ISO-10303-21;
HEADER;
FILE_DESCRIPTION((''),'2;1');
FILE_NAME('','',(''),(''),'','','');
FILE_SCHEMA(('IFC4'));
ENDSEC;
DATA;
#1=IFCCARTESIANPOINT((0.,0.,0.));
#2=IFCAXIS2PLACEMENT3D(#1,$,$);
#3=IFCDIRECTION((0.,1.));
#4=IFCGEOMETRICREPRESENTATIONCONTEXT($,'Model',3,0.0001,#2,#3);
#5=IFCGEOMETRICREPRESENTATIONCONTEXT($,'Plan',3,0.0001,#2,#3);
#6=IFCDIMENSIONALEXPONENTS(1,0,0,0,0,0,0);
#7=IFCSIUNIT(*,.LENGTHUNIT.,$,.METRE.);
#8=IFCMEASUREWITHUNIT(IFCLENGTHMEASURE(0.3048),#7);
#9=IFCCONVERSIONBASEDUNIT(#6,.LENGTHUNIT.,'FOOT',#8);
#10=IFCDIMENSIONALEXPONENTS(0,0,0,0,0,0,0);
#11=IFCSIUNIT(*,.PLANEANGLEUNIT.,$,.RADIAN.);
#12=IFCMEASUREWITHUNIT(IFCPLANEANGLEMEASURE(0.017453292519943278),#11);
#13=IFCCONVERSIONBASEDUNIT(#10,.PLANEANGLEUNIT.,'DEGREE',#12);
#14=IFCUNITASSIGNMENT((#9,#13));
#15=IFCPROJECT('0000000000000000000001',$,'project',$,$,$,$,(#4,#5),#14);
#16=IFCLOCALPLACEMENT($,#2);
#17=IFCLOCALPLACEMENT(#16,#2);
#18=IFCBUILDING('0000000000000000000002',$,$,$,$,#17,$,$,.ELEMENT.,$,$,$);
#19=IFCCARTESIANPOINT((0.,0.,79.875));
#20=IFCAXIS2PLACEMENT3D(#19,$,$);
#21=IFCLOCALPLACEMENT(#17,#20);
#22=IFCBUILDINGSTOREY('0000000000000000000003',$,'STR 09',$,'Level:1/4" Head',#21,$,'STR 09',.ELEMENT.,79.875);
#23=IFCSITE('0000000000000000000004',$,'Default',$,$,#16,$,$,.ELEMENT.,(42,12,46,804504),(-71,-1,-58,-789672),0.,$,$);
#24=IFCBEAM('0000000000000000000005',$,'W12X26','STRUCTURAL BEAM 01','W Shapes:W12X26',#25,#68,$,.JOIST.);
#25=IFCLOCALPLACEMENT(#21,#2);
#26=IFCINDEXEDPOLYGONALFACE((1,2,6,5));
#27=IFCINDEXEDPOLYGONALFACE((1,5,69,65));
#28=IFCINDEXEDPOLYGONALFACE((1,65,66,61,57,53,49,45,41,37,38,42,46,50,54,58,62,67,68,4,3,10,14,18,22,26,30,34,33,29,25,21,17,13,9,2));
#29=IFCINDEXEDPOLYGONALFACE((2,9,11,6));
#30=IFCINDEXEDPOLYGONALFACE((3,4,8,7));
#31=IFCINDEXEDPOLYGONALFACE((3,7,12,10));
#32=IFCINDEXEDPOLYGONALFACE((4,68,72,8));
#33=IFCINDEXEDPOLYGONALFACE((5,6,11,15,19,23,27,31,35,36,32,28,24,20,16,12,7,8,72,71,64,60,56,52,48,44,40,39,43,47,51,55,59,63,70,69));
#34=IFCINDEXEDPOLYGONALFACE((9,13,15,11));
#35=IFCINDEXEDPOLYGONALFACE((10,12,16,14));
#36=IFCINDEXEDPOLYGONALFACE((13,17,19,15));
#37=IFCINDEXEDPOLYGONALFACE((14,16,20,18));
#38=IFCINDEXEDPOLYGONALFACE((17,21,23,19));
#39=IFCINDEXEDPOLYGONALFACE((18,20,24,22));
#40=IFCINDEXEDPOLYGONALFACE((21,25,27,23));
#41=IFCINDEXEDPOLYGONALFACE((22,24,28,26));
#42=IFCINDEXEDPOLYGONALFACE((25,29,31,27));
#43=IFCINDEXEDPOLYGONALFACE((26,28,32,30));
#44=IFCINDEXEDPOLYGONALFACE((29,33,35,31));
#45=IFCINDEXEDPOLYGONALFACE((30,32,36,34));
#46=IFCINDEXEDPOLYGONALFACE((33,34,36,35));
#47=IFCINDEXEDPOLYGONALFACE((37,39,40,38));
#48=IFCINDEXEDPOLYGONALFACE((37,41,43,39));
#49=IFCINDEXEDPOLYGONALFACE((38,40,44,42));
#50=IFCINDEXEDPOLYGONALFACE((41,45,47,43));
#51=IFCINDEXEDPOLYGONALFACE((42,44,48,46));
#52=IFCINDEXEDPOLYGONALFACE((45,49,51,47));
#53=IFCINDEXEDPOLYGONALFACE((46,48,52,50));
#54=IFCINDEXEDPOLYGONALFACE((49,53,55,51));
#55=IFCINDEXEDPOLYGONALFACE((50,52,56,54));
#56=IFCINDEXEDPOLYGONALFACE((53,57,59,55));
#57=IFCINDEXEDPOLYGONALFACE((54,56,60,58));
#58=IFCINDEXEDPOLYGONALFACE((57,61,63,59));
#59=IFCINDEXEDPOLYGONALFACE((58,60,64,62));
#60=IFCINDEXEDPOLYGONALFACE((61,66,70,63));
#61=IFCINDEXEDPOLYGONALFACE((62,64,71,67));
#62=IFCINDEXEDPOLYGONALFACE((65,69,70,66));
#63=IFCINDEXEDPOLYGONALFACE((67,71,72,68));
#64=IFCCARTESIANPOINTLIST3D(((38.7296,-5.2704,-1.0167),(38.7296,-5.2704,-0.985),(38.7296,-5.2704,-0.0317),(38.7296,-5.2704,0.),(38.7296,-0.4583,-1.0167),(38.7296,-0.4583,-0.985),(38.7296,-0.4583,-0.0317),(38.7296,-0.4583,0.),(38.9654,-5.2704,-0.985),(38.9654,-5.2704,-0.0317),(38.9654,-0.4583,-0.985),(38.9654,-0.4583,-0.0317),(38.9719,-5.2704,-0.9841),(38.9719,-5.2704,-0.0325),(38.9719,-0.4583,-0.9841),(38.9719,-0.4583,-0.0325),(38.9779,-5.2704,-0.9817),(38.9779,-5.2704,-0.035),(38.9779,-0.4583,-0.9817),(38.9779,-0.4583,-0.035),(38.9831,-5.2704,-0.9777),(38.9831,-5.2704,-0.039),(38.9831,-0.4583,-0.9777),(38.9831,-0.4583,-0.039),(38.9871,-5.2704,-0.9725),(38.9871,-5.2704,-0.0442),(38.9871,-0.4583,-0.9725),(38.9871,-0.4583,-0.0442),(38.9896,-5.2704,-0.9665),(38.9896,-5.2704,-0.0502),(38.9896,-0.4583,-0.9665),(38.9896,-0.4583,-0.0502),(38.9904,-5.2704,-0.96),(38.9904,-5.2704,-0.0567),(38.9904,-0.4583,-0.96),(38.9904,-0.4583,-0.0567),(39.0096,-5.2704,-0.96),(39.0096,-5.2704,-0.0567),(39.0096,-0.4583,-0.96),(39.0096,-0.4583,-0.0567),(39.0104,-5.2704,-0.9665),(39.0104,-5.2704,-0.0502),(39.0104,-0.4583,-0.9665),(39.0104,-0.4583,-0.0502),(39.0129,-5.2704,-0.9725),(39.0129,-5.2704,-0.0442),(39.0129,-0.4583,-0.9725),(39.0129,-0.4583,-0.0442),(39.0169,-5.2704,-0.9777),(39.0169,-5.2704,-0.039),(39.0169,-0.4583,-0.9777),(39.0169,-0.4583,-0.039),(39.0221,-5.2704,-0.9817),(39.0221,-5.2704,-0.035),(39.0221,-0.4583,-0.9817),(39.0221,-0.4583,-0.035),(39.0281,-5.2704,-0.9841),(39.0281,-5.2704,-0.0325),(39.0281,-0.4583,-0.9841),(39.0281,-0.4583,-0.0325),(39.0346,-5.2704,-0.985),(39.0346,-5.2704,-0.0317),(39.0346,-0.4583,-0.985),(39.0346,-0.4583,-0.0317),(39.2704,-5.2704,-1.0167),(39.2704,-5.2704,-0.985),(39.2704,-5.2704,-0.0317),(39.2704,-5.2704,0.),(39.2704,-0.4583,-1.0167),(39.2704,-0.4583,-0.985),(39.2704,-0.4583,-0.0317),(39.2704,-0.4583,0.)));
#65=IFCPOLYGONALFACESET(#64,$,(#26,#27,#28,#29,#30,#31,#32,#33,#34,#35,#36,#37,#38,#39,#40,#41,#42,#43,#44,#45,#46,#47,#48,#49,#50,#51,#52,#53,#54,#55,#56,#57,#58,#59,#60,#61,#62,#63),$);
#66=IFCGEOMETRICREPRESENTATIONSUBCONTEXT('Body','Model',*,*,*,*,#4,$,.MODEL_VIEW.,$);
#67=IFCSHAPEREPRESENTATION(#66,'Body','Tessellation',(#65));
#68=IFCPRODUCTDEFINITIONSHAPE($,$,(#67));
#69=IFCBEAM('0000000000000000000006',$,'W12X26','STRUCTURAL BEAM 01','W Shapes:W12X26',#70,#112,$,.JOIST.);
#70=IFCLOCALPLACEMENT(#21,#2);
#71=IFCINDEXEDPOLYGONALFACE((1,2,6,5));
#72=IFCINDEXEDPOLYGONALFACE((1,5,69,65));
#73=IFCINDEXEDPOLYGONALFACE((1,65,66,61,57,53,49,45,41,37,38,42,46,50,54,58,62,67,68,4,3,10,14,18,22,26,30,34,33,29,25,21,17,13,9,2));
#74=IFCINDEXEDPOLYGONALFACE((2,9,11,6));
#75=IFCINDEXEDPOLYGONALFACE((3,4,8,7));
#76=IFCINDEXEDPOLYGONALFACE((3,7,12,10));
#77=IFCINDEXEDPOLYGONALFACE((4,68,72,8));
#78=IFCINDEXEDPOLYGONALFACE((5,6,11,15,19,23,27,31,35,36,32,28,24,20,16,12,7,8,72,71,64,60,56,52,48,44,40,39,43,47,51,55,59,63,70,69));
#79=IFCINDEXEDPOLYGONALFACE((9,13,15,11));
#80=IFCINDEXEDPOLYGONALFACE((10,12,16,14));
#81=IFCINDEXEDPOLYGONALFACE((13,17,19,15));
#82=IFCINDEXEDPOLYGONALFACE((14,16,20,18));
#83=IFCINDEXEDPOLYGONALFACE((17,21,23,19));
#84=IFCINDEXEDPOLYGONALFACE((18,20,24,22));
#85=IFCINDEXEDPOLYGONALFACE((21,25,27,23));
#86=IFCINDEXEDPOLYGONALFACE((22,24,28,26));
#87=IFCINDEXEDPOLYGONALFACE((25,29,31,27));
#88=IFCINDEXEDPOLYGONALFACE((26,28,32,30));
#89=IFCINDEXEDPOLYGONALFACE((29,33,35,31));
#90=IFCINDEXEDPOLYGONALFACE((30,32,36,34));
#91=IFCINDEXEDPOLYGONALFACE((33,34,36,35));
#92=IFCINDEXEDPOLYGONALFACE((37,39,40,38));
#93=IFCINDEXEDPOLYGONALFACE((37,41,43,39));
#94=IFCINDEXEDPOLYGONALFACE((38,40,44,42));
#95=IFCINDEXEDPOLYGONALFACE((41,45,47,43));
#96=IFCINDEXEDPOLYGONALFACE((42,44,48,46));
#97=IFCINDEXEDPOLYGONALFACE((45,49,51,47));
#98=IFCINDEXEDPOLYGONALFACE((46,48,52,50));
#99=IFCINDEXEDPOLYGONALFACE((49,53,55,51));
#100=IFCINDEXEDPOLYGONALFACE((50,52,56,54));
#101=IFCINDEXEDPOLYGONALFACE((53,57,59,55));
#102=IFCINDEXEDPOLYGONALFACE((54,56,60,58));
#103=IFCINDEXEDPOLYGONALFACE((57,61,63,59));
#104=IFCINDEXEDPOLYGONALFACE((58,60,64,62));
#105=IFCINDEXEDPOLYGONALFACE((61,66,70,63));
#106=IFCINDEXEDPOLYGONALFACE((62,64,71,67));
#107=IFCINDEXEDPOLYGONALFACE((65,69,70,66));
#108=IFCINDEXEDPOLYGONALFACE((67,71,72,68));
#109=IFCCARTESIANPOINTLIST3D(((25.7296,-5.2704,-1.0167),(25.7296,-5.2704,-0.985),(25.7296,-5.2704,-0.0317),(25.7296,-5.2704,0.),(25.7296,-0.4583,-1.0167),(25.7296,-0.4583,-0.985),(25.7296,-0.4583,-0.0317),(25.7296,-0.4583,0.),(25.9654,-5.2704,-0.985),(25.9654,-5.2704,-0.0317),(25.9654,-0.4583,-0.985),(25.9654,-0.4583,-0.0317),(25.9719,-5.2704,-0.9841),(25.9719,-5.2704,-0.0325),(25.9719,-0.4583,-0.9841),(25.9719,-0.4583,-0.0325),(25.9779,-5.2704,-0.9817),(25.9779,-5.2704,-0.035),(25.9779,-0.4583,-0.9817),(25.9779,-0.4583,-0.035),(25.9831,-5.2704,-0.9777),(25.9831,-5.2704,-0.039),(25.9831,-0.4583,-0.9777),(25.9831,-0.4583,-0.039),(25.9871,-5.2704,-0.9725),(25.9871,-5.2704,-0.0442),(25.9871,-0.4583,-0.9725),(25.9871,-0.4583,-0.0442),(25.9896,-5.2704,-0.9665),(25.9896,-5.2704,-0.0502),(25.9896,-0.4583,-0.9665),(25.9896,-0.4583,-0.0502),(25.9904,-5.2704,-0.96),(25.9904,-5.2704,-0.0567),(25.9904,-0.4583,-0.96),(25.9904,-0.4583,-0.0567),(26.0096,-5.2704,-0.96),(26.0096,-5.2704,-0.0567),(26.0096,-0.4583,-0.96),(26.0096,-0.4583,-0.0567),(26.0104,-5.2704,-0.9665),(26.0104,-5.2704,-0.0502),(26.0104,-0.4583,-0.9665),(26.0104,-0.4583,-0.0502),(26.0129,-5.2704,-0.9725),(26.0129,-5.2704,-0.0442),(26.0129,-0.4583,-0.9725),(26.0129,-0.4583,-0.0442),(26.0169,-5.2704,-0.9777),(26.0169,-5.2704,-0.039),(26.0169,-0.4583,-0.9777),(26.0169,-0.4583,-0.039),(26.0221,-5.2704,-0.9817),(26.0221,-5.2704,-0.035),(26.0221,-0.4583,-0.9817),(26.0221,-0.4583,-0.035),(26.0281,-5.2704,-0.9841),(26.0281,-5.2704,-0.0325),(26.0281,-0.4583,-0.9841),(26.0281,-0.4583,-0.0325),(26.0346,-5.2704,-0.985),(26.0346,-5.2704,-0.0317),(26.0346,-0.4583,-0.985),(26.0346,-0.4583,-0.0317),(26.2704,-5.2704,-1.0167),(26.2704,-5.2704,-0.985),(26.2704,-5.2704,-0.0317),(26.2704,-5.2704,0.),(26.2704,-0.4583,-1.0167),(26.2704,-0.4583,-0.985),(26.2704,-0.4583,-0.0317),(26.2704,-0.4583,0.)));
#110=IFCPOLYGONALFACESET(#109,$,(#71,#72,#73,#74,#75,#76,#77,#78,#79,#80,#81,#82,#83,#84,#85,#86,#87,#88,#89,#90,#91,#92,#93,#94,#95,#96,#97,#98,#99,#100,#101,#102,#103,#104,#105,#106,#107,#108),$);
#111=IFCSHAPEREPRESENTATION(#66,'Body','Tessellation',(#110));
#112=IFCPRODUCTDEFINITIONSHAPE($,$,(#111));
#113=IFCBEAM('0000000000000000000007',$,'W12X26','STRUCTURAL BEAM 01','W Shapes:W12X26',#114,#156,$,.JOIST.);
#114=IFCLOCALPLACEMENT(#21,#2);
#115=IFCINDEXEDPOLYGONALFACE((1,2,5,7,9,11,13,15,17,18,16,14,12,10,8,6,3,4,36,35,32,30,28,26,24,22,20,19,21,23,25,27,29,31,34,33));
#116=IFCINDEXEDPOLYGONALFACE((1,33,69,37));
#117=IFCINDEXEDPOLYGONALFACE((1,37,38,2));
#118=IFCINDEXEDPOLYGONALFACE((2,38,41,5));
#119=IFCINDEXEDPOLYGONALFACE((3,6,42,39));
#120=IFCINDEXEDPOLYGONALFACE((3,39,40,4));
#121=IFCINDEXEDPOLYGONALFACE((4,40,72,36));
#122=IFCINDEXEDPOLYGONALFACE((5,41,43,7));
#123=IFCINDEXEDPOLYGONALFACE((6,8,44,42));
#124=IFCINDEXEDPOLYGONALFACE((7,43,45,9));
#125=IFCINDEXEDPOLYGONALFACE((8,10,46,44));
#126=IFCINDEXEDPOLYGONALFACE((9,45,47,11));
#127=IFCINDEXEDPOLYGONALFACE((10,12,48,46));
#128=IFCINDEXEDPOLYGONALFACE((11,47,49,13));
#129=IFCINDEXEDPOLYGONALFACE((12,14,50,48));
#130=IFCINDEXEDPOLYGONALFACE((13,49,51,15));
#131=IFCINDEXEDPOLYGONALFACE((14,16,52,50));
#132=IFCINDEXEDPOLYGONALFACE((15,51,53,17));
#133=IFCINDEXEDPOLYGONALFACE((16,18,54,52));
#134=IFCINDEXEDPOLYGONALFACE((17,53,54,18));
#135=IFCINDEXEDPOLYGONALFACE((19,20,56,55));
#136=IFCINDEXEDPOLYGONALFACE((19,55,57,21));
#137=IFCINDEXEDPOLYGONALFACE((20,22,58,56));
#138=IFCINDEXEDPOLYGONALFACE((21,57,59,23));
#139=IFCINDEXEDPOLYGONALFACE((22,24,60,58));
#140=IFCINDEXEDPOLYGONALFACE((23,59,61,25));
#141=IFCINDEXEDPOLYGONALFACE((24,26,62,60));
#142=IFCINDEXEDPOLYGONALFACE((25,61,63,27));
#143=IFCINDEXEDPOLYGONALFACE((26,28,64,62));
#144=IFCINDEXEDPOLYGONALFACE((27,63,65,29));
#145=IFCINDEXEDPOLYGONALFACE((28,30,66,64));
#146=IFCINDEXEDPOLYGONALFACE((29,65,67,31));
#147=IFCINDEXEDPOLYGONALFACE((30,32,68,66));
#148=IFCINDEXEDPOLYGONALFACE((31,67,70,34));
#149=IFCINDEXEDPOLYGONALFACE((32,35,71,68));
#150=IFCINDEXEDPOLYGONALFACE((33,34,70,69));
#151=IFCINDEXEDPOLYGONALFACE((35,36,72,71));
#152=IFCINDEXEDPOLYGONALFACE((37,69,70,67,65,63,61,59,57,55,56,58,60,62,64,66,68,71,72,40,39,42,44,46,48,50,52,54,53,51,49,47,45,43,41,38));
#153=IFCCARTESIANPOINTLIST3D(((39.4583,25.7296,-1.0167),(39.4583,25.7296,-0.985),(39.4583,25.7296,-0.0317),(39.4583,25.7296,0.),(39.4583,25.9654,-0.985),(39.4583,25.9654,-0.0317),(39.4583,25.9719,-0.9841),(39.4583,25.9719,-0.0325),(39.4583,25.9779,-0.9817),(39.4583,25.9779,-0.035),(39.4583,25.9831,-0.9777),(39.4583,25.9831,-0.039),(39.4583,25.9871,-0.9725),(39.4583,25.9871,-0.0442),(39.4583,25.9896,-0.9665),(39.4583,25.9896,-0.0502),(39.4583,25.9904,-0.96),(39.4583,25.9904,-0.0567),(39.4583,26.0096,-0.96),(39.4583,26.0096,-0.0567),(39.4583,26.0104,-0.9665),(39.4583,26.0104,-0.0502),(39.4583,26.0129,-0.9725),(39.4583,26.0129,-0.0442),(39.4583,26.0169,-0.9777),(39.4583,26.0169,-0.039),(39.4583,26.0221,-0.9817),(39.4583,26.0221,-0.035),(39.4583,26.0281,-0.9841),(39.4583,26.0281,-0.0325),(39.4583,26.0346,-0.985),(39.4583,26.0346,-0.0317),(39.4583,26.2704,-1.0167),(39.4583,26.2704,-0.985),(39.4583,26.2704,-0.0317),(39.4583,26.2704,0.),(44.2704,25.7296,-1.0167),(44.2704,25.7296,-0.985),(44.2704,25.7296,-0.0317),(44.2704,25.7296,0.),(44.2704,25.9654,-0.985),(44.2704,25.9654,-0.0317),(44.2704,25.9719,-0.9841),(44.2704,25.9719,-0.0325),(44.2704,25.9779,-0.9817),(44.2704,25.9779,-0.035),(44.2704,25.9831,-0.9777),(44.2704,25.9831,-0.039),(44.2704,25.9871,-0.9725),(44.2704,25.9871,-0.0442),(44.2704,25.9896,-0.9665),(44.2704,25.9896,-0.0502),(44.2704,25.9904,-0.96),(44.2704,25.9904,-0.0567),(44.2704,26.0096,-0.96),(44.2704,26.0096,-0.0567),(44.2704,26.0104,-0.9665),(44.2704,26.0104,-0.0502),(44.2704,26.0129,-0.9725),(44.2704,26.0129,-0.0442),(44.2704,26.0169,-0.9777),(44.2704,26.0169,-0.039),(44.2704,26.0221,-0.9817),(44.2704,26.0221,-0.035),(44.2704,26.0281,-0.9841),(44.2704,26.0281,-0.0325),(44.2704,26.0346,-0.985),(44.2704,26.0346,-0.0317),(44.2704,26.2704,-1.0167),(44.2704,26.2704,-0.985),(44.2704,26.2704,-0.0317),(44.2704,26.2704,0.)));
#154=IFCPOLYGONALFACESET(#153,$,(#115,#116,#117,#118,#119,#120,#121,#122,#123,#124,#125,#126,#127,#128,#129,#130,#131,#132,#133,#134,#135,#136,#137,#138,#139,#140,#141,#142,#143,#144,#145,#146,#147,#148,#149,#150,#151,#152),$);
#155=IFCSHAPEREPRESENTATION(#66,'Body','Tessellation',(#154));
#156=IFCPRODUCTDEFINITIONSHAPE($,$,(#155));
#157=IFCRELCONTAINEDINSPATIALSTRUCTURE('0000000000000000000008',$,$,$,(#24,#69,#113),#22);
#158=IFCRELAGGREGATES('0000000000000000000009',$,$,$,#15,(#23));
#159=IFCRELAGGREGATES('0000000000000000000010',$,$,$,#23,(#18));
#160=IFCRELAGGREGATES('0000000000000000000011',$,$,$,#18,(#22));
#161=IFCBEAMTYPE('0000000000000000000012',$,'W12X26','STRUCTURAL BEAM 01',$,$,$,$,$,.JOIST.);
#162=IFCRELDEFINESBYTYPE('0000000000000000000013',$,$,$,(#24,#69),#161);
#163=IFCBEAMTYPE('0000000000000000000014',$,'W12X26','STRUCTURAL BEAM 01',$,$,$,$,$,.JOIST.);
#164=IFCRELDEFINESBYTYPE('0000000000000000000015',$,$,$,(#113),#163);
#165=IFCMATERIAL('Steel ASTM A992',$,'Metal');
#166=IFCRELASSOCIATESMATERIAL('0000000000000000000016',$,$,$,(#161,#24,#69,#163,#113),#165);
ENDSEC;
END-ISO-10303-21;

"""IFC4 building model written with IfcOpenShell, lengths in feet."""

from ifc_helpers import new_model, entity, si_unit, converted_unit, direction, frame, origin, place, context, subcontext, project, spatial, line, arc, indexed_curve, outline, extrude, source, transform, mapped, material, type_object, type_shapes, element, save


model = new_model("IFC4")

# Units and contexts
model_context = context("Model", 3, precision=0.0001, world=origin(), true_north=direction((0.0, 1.0)))
plan_context = context("Plan", 3, precision=0.0001, world=origin(), true_north=direction((0.0, 1.0)))
body_context = subcontext(model_context, "Body", "Model", "MODEL_VIEW")
ifc_project = project(units=[converted_unit("LENGTHUNIT", "FOOT", entity("IfcLengthMeasure", 0.3048), si_unit("LENGTHUNIT", "METRE"), dimensions=[1, 0, 0, 0, 0, 0, 0]), converted_unit("PLANEANGLEUNIT", "DEGREE", entity("IfcPlaneAngleMeasure", 0.017453292519943278), si_unit("PLANEANGLEUNIT", "RADIAN"), dimensions=[0, 0, 0, 0, 0, 0, 0])], contexts=[model_context, plan_context])

# Site, building, storey
site_placement = place(None, origin())
site = spatial("IfcSite", under=ifc_project, at=site_placement, Name="Default", CompositionType="ELEMENT", RefLatitude=(42, 12, 46, 804504), RefLongitude=(-71, -1, -58, -789672), RefElevation=0.0)
building_placement = place(site_placement, origin())
building = spatial("IfcBuilding", under=site, at=building_placement, CompositionType="ELEMENT")
storey_placement = place(building_placement, frame((0.0, 0.0, 79.875)))
storey = spatial("IfcBuildingStorey", under=building, at=storey_placement, Name="STR 09", ObjectType="Level:1/4\" Head", LongName="STR 09", CompositionType="ELEMENT", Elevation=79.875)

# Shared definitions
ifc_material = material(Name="Steel ASTM A992", Category="Metal")

# Beams
beam_type_1 = type_object("IfcBeamType", Name="W12X26", Description="STRUCTURAL BEAM 01", PredefinedType="JOIST", material=ifc_material)
shared_shape_1 = source(origin(), body_context, "Body", "SweptSolid", [
    extrude(outline(indexed_curve([(0.4767, -0.2704), (0.5083, -0.2704), (0.5083, 0.2704), (0.4767, 0.2704), (0.4767, 0.0346), (0.4693, 0.0169), (0.4517, 0.0096), (-0.4517, 0.0096), (-0.4693, 0.0169), (-0.4767, 0.0346), (-0.4767, 0.2704), (-0.5083, 0.2704), (-0.5083, -0.2704), (-0.4767, -0.2704), (-0.4767, -0.0346), (-0.4693, -0.0169), (-0.4517, -0.0096), (0.4517, -0.0096), (0.4693, -0.0169), (0.4767, -0.0346)], segments=[line(1, 2, 3, 4, 5), arc(5, 6, 7), line(7, 8), arc(8, 9, 10), line(10, 11, 12, 13, 14, 15), arc(15, 16, 17), line(17, 18), arc(18, 19, 20), line(20, 1)], self_intersect=False)), frame((-2.0417, 0.0, 0.0), z_axis=(1.0, 0.0, 0.0), x_axis=(0.0, 0.0, -1.0)), (0.0, 0.0, 1.0), 4.8121),
])
type_shapes(beam_type_1, [shared_shape_1])
for number, where, z_axis, x_axis, name in (
    (1, (39.0, -2.5, -0.5083), (0.0, 0.0, 1.0), (0.0, -1.0, 0.0), "W12X26"),
    (2, (26.0, -2.5, -0.5083), (0.0, 0.0, 1.0), (0.0, -1.0, 0.0), "W12X26"),
):
    element("IfcBeam", number, at=place(storey_placement, frame(where, z_axis=z_axis, x_axis=x_axis)), inside=storey, type_object=beam_type_1, material=ifc_material, Name=name, Description="STRUCTURAL BEAM 01", ObjectType="W Shapes:W12X26", PredefinedType="JOIST", context=body_context, shape_type="MappedRepresentation", body=[
        mapped(shared_shape_1, transform((0.0, 0.0, 0.0), scale=1.0)),
    ])
beam_type_2 = type_object("IfcBeamType", Name="W12X26", Description="STRUCTURAL BEAM 01", PredefinedType="JOIST", material=ifc_material)
shared_shape_2 = source(origin(), body_context, "Body", "SweptSolid", [
    extrude(outline(indexed_curve([(0.4767, -0.2704), (0.5083, -0.2704), (0.5083, 0.2704), (0.4767, 0.2704), (0.4767, 0.0346), (0.4693, 0.0169), (0.4517, 0.0096), (-0.4517, 0.0096), (-0.4693, 0.0169), (-0.4767, 0.0346), (-0.4767, 0.2704), (-0.5083, 0.2704), (-0.5083, -0.2704), (-0.4767, -0.2704), (-0.4767, -0.0346), (-0.4693, -0.0169), (-0.4517, -0.0096), (0.4517, -0.0096), (0.4693, -0.0169), (0.4767, -0.0346)], segments=[line(1, 2, 3, 4, 5), arc(5, 6, 7), line(7, 8), arc(8, 9, 10), line(10, 11, 12, 13, 14, 15), arc(15, 16, 17), line(17, 18), arc(18, 19, 20), line(20, 1)], self_intersect=False)), frame((-2.7704, 0.0, 0.0), z_axis=(1.0, 0.0, 0.0), x_axis=(0.0, 0.0, -1.0)), (0.0, 0.0, 1.0), 4.8121),
])
type_shapes(beam_type_2, [shared_shape_2])
for number, where, z_axis, x_axis, name in (
    (3, (41.5, 26.0, -0.5083), (0.0, 0.0, 1.0), (-1.0, 0.0, 0.0), "W12X26"),
):
    element("IfcBeam", number, at=place(storey_placement, frame(where, z_axis=z_axis, x_axis=x_axis)), inside=storey, type_object=beam_type_2, material=ifc_material, Name=name, Description="STRUCTURAL BEAM 01", ObjectType="W Shapes:W12X26", PredefinedType="JOIST", context=body_context, shape_type="MappedRepresentation", body=[
        mapped(shared_shape_2, transform((0.0, 0.0, 0.0), scale=1.0)),
    ])

save(model, "model.ifc")
